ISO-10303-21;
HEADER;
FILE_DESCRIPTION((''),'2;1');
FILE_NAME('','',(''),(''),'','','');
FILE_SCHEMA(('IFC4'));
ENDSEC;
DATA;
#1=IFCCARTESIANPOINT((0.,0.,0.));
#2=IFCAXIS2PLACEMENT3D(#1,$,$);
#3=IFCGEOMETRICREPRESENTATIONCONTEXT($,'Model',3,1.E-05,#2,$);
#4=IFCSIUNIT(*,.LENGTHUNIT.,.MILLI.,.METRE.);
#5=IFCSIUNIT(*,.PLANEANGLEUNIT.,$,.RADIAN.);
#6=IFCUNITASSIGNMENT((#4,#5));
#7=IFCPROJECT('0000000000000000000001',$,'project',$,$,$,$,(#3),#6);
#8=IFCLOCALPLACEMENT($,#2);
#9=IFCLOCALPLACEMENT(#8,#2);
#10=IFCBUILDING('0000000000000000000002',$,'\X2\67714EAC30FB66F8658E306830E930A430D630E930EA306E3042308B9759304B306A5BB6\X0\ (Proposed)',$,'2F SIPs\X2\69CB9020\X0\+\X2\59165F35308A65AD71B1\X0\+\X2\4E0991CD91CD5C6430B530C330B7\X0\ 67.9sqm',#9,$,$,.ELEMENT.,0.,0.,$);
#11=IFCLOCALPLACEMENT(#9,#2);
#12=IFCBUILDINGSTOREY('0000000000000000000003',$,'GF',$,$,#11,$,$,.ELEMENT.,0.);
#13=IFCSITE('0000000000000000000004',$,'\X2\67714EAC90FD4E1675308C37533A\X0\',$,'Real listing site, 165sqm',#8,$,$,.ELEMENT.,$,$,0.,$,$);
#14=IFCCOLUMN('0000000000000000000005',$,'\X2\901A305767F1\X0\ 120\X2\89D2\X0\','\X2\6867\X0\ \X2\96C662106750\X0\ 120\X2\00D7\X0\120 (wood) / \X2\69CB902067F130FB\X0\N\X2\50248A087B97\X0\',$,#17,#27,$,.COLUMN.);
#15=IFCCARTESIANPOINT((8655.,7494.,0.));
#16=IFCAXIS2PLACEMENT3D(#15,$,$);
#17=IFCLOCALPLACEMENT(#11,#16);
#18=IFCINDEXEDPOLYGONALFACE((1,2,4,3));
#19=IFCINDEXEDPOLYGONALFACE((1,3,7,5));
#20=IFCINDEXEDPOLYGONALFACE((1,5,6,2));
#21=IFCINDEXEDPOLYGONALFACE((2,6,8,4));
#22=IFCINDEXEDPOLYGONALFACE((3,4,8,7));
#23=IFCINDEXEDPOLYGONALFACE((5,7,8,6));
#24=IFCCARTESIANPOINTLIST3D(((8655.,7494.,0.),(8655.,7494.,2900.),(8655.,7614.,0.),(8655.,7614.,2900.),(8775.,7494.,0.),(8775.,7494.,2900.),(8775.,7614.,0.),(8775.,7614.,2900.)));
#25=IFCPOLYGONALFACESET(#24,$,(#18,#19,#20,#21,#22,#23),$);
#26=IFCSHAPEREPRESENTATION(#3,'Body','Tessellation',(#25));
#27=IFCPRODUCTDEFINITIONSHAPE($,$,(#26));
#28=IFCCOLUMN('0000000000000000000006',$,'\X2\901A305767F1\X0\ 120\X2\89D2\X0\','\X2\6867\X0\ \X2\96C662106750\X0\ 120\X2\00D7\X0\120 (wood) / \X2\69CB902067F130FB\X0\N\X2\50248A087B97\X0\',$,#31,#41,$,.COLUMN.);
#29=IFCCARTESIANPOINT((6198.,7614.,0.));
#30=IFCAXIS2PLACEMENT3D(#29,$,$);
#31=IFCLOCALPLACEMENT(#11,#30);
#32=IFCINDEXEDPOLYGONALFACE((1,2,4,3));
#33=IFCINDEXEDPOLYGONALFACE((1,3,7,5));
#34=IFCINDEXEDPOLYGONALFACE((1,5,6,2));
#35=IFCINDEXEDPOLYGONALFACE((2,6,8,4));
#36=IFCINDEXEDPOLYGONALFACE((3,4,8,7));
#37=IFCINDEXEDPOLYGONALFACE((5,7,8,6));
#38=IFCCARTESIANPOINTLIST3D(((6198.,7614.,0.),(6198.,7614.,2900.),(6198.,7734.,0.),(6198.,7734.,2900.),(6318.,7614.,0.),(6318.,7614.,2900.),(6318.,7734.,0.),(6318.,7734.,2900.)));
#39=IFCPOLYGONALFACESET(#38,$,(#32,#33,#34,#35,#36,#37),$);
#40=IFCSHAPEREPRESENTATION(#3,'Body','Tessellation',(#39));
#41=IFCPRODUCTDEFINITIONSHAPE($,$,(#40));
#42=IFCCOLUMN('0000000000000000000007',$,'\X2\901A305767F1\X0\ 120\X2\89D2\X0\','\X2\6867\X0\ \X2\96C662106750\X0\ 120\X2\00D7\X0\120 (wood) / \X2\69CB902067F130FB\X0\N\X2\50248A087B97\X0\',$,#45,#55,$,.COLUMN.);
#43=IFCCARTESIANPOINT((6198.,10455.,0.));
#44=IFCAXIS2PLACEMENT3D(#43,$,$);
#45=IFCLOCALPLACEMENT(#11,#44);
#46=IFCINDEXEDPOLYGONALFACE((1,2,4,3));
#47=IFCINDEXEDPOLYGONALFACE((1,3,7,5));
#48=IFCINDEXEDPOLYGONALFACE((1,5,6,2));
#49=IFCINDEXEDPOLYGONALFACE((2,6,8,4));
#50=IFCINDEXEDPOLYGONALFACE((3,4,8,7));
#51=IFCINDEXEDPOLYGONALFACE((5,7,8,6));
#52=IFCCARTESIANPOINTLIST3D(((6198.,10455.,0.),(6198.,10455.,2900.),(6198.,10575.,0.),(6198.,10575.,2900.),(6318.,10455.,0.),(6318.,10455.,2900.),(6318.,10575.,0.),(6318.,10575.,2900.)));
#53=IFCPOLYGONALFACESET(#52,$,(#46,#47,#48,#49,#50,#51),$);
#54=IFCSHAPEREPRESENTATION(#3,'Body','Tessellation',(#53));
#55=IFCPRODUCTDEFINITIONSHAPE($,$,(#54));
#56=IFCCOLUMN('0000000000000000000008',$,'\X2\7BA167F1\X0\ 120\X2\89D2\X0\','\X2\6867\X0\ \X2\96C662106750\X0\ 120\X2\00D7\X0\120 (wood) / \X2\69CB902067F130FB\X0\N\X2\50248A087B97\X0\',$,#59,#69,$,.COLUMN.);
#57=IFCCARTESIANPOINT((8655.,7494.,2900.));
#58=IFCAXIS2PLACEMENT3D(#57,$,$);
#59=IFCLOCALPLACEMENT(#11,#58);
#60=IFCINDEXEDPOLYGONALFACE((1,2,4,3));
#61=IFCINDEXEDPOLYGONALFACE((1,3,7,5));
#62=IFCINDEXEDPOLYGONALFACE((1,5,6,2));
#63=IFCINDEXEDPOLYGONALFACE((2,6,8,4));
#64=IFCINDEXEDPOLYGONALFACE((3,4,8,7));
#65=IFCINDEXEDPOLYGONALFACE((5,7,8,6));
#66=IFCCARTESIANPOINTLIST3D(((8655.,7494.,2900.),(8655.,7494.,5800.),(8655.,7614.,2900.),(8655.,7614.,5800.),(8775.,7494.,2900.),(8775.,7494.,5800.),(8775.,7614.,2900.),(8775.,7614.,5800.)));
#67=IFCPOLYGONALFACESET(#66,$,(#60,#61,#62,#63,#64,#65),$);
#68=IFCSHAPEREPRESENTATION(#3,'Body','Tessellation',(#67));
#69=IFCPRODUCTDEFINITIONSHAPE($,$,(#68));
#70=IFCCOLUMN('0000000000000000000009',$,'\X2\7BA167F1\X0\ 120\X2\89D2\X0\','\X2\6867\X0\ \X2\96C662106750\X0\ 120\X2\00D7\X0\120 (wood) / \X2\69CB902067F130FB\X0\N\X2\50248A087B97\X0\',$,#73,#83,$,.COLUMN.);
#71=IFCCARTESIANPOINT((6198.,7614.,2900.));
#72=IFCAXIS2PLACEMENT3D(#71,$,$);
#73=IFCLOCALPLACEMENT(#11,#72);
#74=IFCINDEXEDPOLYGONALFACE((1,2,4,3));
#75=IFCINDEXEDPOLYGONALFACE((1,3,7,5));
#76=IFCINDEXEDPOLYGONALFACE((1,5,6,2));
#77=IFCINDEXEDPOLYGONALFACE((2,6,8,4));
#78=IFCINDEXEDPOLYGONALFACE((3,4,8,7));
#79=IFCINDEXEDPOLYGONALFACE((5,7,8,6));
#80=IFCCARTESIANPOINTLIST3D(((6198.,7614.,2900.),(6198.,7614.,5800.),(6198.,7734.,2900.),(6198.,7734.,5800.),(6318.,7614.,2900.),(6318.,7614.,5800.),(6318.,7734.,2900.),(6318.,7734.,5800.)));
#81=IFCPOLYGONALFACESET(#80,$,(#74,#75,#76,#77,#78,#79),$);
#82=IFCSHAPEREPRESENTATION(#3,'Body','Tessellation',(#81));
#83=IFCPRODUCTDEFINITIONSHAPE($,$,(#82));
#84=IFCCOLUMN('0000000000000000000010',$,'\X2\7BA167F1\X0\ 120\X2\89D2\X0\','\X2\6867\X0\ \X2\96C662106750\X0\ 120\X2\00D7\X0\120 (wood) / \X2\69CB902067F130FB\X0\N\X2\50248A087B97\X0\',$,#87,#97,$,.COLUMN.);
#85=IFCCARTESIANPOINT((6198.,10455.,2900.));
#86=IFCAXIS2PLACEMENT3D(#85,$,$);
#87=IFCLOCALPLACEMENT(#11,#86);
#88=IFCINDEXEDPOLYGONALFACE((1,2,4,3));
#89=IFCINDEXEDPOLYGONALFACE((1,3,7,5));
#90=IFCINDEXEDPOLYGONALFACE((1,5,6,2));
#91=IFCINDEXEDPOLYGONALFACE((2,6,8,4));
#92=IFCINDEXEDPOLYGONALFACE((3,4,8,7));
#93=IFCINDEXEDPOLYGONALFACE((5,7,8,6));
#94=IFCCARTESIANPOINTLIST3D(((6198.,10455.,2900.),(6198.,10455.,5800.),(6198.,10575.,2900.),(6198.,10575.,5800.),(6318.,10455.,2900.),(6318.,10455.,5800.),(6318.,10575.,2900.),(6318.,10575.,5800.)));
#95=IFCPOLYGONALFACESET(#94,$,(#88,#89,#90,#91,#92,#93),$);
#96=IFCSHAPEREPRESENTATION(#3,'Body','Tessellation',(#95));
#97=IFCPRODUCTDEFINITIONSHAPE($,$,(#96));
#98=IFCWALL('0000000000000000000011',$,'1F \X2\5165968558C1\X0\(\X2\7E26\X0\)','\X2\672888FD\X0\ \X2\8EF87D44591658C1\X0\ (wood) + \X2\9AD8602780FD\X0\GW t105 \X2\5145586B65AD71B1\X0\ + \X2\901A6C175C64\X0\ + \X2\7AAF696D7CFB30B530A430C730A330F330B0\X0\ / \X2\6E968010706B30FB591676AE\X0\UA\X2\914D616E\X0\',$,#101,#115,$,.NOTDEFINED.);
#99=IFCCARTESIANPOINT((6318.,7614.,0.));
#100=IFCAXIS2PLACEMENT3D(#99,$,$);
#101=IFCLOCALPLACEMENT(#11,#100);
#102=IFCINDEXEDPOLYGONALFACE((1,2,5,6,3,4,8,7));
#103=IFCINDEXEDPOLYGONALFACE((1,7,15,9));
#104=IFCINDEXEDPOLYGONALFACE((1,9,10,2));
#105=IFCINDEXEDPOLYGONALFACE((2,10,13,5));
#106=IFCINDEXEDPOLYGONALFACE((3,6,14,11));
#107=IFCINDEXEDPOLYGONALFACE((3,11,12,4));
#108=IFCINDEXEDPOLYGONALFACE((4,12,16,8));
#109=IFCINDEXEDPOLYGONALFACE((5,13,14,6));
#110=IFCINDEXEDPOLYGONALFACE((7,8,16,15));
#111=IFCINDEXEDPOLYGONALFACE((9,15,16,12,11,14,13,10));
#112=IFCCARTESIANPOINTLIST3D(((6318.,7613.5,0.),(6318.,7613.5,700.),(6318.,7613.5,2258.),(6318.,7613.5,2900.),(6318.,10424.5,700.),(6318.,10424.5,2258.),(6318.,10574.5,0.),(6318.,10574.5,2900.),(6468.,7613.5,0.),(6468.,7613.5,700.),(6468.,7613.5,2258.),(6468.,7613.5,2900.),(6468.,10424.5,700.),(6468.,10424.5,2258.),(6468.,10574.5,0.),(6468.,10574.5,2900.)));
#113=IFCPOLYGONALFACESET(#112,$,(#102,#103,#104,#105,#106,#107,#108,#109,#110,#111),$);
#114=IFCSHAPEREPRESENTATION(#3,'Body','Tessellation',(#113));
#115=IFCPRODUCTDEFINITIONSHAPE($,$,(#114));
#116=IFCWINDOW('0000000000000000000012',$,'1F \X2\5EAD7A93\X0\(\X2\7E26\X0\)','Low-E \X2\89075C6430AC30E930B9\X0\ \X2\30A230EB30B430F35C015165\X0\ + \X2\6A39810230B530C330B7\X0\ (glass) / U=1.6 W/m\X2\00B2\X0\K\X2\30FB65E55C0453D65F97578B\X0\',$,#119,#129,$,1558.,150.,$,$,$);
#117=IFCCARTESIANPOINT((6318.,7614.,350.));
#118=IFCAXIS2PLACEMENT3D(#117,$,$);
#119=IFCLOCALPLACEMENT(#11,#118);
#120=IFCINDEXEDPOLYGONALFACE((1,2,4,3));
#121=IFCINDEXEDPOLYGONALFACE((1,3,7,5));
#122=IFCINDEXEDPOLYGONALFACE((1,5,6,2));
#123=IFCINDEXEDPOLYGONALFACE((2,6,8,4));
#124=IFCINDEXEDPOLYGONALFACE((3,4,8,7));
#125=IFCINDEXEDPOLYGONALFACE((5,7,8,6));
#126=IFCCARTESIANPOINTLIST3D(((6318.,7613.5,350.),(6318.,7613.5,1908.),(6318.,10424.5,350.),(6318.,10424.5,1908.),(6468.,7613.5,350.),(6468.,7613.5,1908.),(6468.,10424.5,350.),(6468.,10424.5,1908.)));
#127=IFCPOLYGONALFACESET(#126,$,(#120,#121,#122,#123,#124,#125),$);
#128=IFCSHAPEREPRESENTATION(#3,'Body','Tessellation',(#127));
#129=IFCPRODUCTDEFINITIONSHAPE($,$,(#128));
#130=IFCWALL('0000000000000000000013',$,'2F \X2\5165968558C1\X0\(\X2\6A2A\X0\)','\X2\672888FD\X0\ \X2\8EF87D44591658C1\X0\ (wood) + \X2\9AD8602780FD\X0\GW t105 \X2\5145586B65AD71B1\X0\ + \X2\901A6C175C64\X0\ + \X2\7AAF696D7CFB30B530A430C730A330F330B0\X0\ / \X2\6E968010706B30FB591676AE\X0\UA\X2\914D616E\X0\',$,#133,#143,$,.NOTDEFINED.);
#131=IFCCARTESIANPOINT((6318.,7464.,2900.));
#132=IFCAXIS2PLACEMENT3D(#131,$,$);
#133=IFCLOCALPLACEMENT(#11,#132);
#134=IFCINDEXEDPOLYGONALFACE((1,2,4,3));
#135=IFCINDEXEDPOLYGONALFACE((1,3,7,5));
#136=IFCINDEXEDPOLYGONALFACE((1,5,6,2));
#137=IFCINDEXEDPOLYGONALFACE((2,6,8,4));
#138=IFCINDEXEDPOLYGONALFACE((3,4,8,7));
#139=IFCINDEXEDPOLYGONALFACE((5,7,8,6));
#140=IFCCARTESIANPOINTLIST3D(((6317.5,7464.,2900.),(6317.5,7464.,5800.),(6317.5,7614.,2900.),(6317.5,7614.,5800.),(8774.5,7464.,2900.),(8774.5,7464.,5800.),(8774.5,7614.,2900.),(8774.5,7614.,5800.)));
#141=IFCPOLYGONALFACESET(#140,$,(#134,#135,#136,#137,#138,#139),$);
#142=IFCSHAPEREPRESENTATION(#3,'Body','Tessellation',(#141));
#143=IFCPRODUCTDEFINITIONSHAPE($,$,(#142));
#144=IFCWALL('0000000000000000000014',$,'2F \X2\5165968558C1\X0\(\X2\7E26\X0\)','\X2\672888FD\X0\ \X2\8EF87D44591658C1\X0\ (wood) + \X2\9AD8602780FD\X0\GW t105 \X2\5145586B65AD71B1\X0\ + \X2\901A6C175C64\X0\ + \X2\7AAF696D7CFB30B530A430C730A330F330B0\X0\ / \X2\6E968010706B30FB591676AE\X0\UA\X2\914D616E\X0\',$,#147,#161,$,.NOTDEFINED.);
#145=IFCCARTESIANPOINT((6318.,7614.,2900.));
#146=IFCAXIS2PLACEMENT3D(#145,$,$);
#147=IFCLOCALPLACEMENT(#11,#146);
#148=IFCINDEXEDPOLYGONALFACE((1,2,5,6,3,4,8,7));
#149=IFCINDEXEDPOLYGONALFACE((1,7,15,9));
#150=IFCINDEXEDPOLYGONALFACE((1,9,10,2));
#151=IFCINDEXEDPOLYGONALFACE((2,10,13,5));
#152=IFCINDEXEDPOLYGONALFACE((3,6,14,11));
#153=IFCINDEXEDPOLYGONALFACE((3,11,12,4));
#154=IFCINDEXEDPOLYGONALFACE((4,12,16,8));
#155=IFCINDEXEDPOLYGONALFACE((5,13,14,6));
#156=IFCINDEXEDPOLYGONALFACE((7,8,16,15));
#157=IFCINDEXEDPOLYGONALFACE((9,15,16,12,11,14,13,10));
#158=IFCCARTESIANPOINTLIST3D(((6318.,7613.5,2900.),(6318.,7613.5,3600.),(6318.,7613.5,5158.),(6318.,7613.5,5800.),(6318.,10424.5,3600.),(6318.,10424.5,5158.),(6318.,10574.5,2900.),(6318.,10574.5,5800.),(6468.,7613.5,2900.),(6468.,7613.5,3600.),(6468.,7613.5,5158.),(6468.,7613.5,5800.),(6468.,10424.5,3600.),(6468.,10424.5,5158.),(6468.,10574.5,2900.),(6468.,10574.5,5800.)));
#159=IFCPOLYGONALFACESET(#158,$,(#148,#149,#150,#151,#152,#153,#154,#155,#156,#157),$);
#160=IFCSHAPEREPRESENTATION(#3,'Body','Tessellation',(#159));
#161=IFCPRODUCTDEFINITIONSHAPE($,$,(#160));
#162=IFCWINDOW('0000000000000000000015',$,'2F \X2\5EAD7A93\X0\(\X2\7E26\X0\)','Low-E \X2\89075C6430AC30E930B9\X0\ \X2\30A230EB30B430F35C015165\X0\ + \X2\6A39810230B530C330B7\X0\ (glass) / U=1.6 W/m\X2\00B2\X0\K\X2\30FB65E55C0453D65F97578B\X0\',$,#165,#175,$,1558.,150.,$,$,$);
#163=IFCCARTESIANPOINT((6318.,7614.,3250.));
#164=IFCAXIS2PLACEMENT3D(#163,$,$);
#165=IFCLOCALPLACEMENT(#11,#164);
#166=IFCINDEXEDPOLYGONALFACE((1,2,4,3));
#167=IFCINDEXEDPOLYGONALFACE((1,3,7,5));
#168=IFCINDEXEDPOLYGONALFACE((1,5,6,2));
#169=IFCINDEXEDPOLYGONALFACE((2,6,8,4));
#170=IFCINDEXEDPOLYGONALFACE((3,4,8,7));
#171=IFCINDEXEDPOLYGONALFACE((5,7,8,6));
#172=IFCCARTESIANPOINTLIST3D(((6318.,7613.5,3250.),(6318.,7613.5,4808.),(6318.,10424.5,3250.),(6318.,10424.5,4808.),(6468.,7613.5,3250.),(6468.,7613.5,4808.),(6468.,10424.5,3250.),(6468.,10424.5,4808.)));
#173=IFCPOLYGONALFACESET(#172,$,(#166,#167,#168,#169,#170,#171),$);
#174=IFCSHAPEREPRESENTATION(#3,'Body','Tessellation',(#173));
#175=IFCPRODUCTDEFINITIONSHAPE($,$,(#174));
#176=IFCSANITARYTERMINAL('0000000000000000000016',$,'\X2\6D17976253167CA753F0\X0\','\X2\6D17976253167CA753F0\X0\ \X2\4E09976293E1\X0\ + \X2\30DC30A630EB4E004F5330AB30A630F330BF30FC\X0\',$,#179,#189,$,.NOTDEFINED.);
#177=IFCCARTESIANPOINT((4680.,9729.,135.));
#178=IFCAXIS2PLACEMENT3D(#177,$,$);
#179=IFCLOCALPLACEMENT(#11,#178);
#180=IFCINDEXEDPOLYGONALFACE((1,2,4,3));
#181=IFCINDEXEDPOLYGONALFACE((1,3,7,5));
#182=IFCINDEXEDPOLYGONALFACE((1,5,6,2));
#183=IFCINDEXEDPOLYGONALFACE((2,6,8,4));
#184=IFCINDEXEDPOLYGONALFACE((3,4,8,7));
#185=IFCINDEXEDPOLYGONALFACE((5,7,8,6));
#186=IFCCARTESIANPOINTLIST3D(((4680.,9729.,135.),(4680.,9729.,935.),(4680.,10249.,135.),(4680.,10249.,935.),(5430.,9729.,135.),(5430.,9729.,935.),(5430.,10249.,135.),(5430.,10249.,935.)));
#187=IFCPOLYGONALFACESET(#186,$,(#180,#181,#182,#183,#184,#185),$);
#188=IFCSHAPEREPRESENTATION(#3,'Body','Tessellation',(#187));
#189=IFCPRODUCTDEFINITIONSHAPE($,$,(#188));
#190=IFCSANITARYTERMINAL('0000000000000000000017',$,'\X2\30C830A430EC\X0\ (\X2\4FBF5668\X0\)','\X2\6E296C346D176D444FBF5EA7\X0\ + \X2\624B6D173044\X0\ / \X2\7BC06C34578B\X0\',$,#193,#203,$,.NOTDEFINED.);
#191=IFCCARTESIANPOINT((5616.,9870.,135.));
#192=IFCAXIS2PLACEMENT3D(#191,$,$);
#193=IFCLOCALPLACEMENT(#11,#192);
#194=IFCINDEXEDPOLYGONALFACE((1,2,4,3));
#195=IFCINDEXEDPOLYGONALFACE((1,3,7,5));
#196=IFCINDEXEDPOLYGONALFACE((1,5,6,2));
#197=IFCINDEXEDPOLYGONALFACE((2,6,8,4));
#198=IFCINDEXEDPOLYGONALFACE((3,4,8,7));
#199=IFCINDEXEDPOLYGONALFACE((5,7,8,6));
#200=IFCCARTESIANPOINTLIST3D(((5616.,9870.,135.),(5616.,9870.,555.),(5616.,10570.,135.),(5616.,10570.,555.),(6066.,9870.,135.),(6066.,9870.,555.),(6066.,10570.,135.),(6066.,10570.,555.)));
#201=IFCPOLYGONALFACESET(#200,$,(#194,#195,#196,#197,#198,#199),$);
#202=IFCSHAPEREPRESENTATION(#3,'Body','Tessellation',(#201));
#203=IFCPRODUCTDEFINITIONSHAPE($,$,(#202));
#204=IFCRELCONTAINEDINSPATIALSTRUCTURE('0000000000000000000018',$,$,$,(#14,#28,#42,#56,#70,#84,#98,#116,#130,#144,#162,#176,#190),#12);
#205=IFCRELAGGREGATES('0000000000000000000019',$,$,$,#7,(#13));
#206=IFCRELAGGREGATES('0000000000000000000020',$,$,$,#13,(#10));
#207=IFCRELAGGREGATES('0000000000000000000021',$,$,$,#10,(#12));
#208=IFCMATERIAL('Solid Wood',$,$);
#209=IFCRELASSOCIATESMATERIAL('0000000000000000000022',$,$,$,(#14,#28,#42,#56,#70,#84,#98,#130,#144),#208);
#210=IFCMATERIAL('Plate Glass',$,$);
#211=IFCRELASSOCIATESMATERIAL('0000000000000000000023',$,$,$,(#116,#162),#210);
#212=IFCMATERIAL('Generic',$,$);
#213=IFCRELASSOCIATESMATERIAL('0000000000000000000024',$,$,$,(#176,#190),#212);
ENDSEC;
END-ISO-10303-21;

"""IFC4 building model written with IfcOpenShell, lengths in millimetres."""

from ifc_helpers import new_model, si_unit, frame, frame_2d, origin, place, context, project, spatial, rectangle, extrude, material, element, fill, save


model = new_model("IFC4")

# Units and contexts
model_context = context("Model", 3, precision=1e-05, world=origin())
ifc_project = project(units=[si_unit("LENGTHUNIT", "METRE", prefix="MILLI"), si_unit("PLANEANGLEUNIT", "RADIAN")], contexts=[model_context])

# Site, building, storey
site_placement = place(None, origin())
site = spatial("IfcSite", under=ifc_project, at=site_placement, Name="東京都世田谷区", ObjectType="Real listing site, 165sqm", CompositionType="ELEMENT", RefElevation=0.0)
building_placement = place(site_placement, origin())
building = spatial("IfcBuilding", under=site, at=building_placement, Name="東京・書斎とライブラリのある静かな家 (Proposed)", ObjectType="2F SIPs構造+外張り断熱+三重重層サッシ 67.9sqm", CompositionType="ELEMENT", ElevationOfRefHeight=0.0, ElevationOfTerrain=0.0)
storey_placement = place(building_placement, origin())
storey = spatial("IfcBuildingStorey", under=building, at=storey_placement, Name="GF", CompositionType="ELEMENT", Elevation=0.0)

# Columns
ifc_material_1 = material(Name="Solid Wood")
column_1_placement = place(storey_placement, frame((8655.0, 7494.0, 0.0)))
element("IfcColumn", 1, at=column_1_placement, inside=storey, material=ifc_material_1, Name="通し柱 120角", Description="桧 集成材 120×120 (wood) / 構造柱・N値計算", PredefinedType="COLUMN", context=model_context, shape_type="SweptSolid", body=[
    extrude(rectangle(XDim=120.0, YDim=120.0, at=frame_2d((60.0, 60.0))), frame((8655.0, 7494.0, 0.0)), (0.0, 0.0, 1.0), 2900.0),
])
column_2_placement = place(storey_placement, frame((6198.0, 7614.0, 0.0)))
element("IfcColumn", 2, at=column_2_placement, inside=storey, material=ifc_material_1, Name="通し柱 120角", Description="桧 集成材 120×120 (wood) / 構造柱・N値計算", PredefinedType="COLUMN", context=model_context, shape_type="SweptSolid", body=[
    extrude(rectangle(XDim=120.0, YDim=120.0, at=frame_2d((60.0, 60.0))), frame((6198.0, 7614.0, 0.0)), (0.0, 0.0, 1.0), 2900.0),
])
column_3_placement = place(storey_placement, frame((6198.0, 10455.0, 0.0)))
element("IfcColumn", 3, at=column_3_placement, inside=storey, material=ifc_material_1, Name="通し柱 120角", Description="桧 集成材 120×120 (wood) / 構造柱・N値計算", PredefinedType="COLUMN", context=model_context, shape_type="SweptSolid", body=[
    extrude(rectangle(XDim=120.0, YDim=120.0, at=frame_2d((60.0, 60.0))), frame((6198.0, 10455.0, 0.0)), (0.0, 0.0, 1.0), 2900.0),
])
column_4_placement = place(storey_placement, frame((8655.0, 7494.0, 2900.0)))
element("IfcColumn", 4, at=column_4_placement, inside=storey, material=ifc_material_1, Name="管柱 120角", Description="桧 集成材 120×120 (wood) / 構造柱・N値計算", PredefinedType="COLUMN", context=model_context, shape_type="SweptSolid", body=[
    extrude(rectangle(XDim=120.0, YDim=120.0, at=frame_2d((60.0, 60.0))), frame((8655.0, 7494.0, 2900.0)), (0.0, 0.0, 1.0), 2900.0),
])
column_5_placement = place(storey_placement, frame((6198.0, 7614.0, 2900.0)))
element("IfcColumn", 5, at=column_5_placement, inside=storey, material=ifc_material_1, Name="管柱 120角", Description="桧 集成材 120×120 (wood) / 構造柱・N値計算", PredefinedType="COLUMN", context=model_context, shape_type="SweptSolid", body=[
    extrude(rectangle(XDim=120.0, YDim=120.0, at=frame_2d((60.0, 60.0))), frame((6198.0, 7614.0, 2900.0)), (0.0, 0.0, 1.0), 2900.0),
])
column_6_placement = place(storey_placement, frame((6198.0, 10455.0, 2900.0)))
element("IfcColumn", 6, at=column_6_placement, inside=storey, material=ifc_material_1, Name="管柱 120角", Description="桧 集成材 120×120 (wood) / 構造柱・N値計算", PredefinedType="COLUMN", context=model_context, shape_type="SweptSolid", body=[
    extrude(rectangle(XDim=120.0, YDim=120.0, at=frame_2d((60.0, 60.0))), frame((6198.0, 10455.0, 2900.0)), (0.0, 0.0, 1.0), 2900.0),
])

# Wall, opening, window
wall_1_placement = place(storey_placement, frame((6318.0, 7614.0, 0.0)))
wall_1 = element("IfcWall", 7, at=wall_1_placement, inside=storey, material=ifc_material_1, Name="1F 入隅壁(縦)", Description="木製 軸組外壁 (wood) + 高性能GW t105 充填断熱 + 通気層 + 窯業系サイディング / 準耐火・外皮UA配慮", PredefinedType="NOTDEFINED", context=model_context, shape_type="SweptSolid", body=[
    extrude(rectangle(XDim=150.0, YDim=2961.0, at=frame_2d((75.0, 1480.0))), frame((6318.0, 7614.0, 0.0)), (0.0, 0.0, 1.0), 2900.0),
])
opening_1_placement = place(storey_placement, frame((6318.0, 7614.0, 350.0)))
opening_1 = element("IfcOpeningElement", 8, at=opening_1_placement, cuts=wall_1, PredefinedType="NOTDEFINED", context=model_context, shape_type="SweptSolid", body=[
    extrude(rectangle(XDim=150.0, YDim=2811.0, at=frame_2d((75.0, 1405.0))), frame((6318.0, 7614.0, 350.0)), (0.0, 0.0, 1.0), 1558.0),
])
ifc_material_2 = material(Name="Plate Glass")
window_1_placement = place(storey_placement, frame((6318.0, 7614.0, 350.0)))
window_1 = element("IfcWindow", 9, at=window_1_placement, inside=storey, material=ifc_material_2, Name="1F 庭窓(縦)", Description="Low-E 複層ガラス アルゴン封入 + 樹脂サッシ (glass) / U=1.6 W/m²K・日射取得型", OverallHeight=1558.0, OverallWidth=150.0, context=model_context, shape_type="SweptSolid", body=[
    extrude(rectangle(XDim=150.0, YDim=2811.0, at=frame_2d((75.0, 1405.0))), frame((6318.0, 7614.0, 350.0)), (0.0, 0.0, 1.0), 1558.0),
])
fill(opening_1, window_1)

# Wall
wall_2_placement = place(storey_placement, frame((6318.0, 7464.0, 2900.0)))
element("IfcWall", 10, at=wall_2_placement, inside=storey, material=ifc_material_1, Name="2F 入隅壁(横)", Description="木製 軸組外壁 (wood) + 高性能GW t105 充填断熱 + 通気層 + 窯業系サイディング / 準耐火・外皮UA配慮", PredefinedType="NOTDEFINED", context=model_context, shape_type="SweptSolid", body=[
    extrude(rectangle(XDim=2457.0, YDim=150.0, at=frame_2d((1228.0, 75.0))), frame((6318.0, 7464.0, 2900.0)), (0.0, 0.0, 1.0), 2900.0),
])

# Wall, opening, window
wall_3_placement = place(storey_placement, frame((6318.0, 7614.0, 2900.0)))
wall_3 = element("IfcWall", 11, at=wall_3_placement, inside=storey, material=ifc_material_1, Name="2F 入隅壁(縦)", Description="木製 軸組外壁 (wood) + 高性能GW t105 充填断熱 + 通気層 + 窯業系サイディング / 準耐火・外皮UA配慮", PredefinedType="NOTDEFINED", context=model_context, shape_type="SweptSolid", body=[
    extrude(rectangle(XDim=150.0, YDim=2961.0, at=frame_2d((75.0, 1480.0))), frame((6318.0, 7614.0, 2900.0)), (0.0, 0.0, 1.0), 2900.0),
])
opening_2_placement = place(storey_placement, frame((6318.0, 7614.0, 3250.0)))
opening_2 = element("IfcOpeningElement", 12, at=opening_2_placement, cuts=wall_3, PredefinedType="NOTDEFINED", context=model_context, shape_type="SweptSolid", body=[
    extrude(rectangle(XDim=150.0, YDim=2811.0, at=frame_2d((75.0, 1405.0))), frame((6318.0, 7614.0, 3250.0)), (0.0, 0.0, 1.0), 1558.0),
])
window_2_placement = place(storey_placement, frame((6318.0, 7614.0, 3250.0)))
window_2 = element("IfcWindow", 13, at=window_2_placement, inside=storey, material=ifc_material_2, Name="2F 庭窓(縦)", Description="Low-E 複層ガラス アルゴン封入 + 樹脂サッシ (glass) / U=1.6 W/m²K・日射取得型", OverallHeight=1558.0, OverallWidth=150.0, context=model_context, shape_type="SweptSolid", body=[
    extrude(rectangle(XDim=150.0, YDim=2811.0, at=frame_2d((75.0, 1405.0))), frame((6318.0, 7614.0, 3250.0)), (0.0, 0.0, 1.0), 1558.0),
])
fill(opening_2, window_2)

# Sanitary terminals
ifc_material_3 = material(Name="Generic")
sanitary_terminal_1_placement = place(storey_placement, frame((4680.0, 9729.0, 135.0)))
element("IfcSanitaryTerminal", 14, at=sanitary_terminal_1_placement, inside=storey, material=ifc_material_3, Name="洗面化粧台", Description="洗面化粧台 三面鏡 + ボウル一体カウンター", PredefinedType="NOTDEFINED", context=model_context, shape_type="SweptSolid", body=[
    extrude(rectangle(XDim=750.0, YDim=520.0, at=frame_2d((375.0, 260.0))), frame((4680.0, 9729.0, 135.0)), (0.0, 0.0, 1.0), 800.0),
])
sanitary_terminal_2_placement = place(storey_placement, frame((5616.0, 9870.0, 135.0)))
element("IfcSanitaryTerminal", 15, at=sanitary_terminal_2_placement, inside=storey, material=ifc_material_3, Name="トイレ (便器)", Description="温水洗浄便座 + 手洗い / 節水型", PredefinedType="NOTDEFINED", context=model_context, shape_type="SweptSolid", body=[
    extrude(rectangle(XDim=450.0, YDim=700.0, at=frame_2d((225.0, 350.0))), frame((5616.0, 9870.0, 135.0)), (0.0, 0.0, 1.0), 420.0),
])

save(model, "model.ifc")
